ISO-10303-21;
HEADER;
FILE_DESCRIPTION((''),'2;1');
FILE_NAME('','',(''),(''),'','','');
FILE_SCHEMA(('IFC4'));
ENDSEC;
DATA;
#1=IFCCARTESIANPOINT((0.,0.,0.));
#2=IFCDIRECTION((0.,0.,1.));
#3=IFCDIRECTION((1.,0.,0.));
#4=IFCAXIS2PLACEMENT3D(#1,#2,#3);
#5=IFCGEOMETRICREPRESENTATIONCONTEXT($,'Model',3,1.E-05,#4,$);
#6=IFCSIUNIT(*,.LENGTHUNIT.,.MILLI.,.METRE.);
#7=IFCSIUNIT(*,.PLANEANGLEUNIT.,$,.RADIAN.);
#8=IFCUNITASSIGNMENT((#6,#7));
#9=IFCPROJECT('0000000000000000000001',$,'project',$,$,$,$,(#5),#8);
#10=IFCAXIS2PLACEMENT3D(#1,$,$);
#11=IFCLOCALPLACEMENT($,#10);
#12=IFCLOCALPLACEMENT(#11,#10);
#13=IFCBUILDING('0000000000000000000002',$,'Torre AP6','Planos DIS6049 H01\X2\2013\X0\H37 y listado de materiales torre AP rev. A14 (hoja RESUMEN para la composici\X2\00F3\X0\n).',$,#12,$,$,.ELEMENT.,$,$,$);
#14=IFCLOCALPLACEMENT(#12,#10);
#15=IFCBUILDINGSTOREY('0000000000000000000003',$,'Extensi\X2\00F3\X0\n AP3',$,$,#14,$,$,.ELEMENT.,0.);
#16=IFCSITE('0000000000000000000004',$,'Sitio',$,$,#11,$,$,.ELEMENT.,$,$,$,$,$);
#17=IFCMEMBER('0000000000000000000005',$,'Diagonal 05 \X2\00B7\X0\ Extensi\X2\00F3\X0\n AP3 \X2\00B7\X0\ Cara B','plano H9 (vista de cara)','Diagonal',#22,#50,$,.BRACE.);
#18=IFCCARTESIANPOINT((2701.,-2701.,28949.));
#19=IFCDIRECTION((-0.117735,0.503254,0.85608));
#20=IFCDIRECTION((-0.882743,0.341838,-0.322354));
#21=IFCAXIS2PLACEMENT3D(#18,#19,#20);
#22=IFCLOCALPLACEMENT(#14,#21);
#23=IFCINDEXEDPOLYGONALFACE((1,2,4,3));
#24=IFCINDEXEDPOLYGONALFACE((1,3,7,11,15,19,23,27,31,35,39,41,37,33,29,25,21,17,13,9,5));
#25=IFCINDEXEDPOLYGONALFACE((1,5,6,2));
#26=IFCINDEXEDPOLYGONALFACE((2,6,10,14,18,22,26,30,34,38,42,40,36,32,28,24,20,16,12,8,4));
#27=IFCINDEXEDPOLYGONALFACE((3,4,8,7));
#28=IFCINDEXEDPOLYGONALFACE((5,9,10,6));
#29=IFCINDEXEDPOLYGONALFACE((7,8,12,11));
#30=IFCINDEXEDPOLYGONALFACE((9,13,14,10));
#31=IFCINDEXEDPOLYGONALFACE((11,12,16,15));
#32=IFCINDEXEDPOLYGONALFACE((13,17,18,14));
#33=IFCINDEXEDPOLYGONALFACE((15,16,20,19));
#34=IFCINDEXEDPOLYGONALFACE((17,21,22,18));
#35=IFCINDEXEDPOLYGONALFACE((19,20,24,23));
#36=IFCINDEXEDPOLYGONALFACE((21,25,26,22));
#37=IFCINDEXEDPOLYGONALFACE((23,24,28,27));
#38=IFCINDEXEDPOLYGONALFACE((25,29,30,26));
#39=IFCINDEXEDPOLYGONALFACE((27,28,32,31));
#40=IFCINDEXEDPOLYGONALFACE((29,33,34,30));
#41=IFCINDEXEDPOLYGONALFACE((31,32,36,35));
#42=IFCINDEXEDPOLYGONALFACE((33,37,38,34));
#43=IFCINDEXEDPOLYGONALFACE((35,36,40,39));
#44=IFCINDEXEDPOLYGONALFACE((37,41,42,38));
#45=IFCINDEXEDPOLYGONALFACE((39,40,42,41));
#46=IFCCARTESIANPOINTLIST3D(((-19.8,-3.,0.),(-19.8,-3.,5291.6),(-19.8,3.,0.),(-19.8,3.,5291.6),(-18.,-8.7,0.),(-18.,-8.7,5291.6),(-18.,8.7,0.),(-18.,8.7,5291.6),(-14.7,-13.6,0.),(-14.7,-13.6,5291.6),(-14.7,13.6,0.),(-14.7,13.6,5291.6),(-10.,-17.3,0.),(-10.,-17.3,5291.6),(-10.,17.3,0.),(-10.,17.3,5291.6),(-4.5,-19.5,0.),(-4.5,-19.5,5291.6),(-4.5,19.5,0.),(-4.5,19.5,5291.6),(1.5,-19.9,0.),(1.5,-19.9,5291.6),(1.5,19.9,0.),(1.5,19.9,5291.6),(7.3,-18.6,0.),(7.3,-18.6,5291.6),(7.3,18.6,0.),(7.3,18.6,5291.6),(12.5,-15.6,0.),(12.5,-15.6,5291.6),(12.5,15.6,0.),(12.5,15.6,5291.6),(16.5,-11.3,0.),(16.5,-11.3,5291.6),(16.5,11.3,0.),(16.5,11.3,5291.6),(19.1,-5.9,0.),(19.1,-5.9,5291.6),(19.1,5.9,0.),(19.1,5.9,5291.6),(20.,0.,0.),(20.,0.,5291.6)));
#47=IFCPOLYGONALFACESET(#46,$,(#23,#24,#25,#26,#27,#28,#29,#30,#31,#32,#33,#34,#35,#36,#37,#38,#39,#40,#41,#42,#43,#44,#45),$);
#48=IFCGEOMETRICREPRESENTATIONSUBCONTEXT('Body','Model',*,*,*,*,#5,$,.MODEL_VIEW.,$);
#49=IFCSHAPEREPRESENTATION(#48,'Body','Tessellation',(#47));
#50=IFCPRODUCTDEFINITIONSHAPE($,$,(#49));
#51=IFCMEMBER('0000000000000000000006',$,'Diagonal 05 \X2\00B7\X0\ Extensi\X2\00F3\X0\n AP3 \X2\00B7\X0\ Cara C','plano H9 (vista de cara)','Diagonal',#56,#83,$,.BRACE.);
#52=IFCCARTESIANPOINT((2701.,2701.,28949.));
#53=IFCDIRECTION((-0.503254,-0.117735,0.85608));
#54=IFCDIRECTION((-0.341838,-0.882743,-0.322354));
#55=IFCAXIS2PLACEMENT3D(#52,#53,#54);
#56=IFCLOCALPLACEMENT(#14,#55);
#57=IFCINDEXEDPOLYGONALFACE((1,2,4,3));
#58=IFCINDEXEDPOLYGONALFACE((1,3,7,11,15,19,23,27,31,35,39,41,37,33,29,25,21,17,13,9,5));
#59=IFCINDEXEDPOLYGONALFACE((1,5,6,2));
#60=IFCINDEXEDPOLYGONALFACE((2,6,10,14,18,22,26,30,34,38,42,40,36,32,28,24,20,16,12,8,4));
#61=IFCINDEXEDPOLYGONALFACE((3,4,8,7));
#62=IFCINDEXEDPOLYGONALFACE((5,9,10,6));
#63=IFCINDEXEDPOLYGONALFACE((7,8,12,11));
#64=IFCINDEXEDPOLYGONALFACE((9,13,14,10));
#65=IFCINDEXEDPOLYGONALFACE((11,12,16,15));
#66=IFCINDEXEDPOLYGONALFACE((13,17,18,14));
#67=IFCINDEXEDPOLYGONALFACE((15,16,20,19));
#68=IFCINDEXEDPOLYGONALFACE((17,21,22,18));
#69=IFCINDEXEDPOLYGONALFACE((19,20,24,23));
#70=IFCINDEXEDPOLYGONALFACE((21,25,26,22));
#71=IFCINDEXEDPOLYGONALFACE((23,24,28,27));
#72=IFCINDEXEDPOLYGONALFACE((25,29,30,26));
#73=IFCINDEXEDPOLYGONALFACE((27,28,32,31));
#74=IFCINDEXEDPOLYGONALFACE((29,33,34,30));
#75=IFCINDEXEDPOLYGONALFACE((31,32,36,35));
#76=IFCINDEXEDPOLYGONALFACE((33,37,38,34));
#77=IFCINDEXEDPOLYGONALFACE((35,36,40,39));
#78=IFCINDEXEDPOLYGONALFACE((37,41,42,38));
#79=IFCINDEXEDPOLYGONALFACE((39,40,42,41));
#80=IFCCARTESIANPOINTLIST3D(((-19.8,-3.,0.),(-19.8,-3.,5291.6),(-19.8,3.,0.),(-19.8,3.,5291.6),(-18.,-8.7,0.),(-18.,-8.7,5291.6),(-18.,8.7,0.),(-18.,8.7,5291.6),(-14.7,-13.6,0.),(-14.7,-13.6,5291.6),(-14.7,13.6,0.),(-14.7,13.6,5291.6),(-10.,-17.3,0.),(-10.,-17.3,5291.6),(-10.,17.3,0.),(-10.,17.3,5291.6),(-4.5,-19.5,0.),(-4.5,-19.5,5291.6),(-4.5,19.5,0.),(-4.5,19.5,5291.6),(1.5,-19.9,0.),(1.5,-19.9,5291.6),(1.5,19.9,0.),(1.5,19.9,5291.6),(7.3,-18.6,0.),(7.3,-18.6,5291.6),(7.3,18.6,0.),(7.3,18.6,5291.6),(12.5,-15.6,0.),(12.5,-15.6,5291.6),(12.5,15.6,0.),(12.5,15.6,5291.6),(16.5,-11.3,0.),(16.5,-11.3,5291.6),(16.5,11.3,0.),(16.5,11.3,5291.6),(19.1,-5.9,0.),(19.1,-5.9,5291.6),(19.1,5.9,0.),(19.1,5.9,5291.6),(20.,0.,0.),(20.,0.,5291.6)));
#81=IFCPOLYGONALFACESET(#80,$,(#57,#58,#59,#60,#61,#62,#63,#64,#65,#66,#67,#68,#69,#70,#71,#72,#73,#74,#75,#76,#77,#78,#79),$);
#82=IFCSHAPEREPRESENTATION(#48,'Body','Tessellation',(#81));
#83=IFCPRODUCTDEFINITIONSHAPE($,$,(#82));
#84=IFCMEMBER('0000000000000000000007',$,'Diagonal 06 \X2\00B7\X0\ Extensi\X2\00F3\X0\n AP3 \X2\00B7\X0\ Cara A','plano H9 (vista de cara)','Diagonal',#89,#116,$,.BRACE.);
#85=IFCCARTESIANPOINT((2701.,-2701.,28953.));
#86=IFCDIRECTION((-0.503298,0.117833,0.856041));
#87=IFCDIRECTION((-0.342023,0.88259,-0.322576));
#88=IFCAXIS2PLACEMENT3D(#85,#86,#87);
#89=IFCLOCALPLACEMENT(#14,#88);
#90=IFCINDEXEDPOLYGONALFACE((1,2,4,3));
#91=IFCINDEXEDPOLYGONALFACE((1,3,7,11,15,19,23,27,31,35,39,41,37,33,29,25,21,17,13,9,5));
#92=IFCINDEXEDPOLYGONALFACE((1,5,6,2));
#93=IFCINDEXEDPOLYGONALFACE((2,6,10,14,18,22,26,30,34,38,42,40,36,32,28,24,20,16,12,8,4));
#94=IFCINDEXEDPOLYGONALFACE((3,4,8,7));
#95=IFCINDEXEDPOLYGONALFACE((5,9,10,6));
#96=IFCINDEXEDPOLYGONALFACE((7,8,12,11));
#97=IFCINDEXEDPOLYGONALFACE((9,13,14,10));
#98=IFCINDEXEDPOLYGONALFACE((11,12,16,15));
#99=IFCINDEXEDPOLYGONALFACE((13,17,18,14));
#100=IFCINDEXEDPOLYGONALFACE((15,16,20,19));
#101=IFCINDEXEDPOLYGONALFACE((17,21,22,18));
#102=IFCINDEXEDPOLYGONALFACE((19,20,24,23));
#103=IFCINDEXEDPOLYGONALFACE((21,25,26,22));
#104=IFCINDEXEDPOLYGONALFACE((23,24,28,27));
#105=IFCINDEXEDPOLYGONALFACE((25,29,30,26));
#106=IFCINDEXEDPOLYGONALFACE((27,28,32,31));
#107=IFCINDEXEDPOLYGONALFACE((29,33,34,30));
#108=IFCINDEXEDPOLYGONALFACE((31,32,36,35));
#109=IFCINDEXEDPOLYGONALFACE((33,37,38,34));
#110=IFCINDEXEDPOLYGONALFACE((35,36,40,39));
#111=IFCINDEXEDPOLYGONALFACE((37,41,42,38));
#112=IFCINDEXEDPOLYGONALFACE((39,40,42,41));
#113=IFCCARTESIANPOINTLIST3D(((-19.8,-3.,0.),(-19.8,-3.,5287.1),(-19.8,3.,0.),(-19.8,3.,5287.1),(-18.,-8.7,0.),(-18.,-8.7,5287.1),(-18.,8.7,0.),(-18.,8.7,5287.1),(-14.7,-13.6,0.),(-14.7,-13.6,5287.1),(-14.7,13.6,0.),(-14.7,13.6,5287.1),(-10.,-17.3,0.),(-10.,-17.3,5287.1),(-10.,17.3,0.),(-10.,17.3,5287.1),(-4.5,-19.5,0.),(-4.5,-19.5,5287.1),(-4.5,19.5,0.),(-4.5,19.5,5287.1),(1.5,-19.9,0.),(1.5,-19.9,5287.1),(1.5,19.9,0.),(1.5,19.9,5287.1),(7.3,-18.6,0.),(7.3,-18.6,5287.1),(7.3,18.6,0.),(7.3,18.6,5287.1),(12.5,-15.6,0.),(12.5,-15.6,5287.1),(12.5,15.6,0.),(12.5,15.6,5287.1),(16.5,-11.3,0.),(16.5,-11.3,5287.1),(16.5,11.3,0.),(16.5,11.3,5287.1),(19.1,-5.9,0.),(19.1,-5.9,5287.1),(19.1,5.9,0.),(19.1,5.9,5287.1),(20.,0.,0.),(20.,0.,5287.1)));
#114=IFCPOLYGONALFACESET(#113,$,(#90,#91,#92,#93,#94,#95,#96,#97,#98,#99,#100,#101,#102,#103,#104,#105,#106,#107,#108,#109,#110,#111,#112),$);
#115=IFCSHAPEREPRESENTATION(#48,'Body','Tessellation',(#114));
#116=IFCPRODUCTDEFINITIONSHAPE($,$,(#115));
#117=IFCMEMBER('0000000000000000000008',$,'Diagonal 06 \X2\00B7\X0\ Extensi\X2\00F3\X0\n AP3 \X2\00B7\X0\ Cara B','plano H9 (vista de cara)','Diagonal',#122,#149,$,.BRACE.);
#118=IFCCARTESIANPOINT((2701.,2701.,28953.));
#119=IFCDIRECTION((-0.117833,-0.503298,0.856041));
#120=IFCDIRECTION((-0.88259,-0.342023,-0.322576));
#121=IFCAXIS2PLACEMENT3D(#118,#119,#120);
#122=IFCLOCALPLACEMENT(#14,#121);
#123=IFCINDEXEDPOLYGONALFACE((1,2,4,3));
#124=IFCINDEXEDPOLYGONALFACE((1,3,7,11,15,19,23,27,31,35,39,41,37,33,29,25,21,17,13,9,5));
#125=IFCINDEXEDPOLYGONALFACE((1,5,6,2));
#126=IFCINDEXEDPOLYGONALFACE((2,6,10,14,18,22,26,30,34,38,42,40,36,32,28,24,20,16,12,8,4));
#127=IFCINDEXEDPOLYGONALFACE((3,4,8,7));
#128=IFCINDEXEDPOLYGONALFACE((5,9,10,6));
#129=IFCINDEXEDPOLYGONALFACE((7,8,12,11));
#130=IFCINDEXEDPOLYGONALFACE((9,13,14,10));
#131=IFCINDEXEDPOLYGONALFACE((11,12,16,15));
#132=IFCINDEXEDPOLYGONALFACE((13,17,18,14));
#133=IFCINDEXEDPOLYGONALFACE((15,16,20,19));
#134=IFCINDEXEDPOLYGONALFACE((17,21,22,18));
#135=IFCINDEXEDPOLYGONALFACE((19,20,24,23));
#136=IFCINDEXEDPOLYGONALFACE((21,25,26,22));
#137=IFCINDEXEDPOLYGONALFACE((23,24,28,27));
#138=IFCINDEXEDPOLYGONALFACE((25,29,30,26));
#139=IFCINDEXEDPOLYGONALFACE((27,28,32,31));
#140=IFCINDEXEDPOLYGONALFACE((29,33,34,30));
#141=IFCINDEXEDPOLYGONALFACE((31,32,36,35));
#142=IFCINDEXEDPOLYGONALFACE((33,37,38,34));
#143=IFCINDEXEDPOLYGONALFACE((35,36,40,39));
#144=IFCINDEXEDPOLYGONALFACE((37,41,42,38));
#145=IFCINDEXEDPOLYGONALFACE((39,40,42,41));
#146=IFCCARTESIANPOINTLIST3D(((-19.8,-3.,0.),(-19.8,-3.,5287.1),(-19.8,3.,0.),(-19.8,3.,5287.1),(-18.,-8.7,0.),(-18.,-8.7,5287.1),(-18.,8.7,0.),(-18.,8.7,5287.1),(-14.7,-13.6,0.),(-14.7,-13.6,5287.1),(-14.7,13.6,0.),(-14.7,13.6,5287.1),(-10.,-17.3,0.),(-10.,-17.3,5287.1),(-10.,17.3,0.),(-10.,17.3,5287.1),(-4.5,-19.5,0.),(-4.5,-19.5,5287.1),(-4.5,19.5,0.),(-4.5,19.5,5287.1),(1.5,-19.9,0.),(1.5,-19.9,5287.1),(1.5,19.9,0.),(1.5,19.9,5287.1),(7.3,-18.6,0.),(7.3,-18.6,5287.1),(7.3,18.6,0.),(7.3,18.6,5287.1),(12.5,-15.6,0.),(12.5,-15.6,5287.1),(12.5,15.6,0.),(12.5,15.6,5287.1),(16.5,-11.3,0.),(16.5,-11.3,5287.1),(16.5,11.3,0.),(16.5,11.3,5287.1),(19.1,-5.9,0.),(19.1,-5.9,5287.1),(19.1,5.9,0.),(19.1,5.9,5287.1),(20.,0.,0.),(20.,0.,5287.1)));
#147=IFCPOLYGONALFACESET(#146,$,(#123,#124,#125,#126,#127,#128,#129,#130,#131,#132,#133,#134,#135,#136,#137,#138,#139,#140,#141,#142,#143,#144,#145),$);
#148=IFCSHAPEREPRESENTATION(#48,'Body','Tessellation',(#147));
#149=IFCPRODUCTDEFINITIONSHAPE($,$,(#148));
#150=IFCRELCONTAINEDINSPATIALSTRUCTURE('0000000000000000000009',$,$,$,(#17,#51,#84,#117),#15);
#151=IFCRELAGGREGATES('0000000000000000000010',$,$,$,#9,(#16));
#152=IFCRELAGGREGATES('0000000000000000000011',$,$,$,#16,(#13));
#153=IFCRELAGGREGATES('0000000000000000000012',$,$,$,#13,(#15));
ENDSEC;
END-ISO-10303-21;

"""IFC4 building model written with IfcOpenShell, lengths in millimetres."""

from ifc_helpers import new_model, si_unit, frame, origin, origin_with_axes, place, context, subcontext, project, spatial, circle, extrude, element, save


model = new_model("IFC4")

# Units and contexts
model_context = context("Model", 3, precision=1e-05, world=origin_with_axes())
body_context = subcontext(model_context, "Body", "Model", "MODEL_VIEW")
ifc_project = project(units=[si_unit("LENGTHUNIT", "METRE", prefix="MILLI"), si_unit("PLANEANGLEUNIT", "RADIAN")], contexts=[model_context])

# Site, building, storey
site_placement = place(None, origin())
site = spatial("IfcSite", under=ifc_project, at=site_placement, Name="Sitio", CompositionType="ELEMENT")
building_placement = place(site_placement, origin())
building = spatial("IfcBuilding", under=site, at=building_placement, Name="Torre AP6", Description="Planos DIS6049 H01–H37 y listado de materiales torre AP rev. A14 (hoja RESUMEN para la composición).", CompositionType="ELEMENT")
storey_placement = place(building_placement, origin())
storey = spatial("IfcBuildingStorey", under=building, at=storey_placement, Name="Extensión AP3", CompositionType="ELEMENT", Elevation=0.0)

# Members
for number, where, z_axis, x_axis, name in (
    (1, (2701.0, -2701.0, 28949.0), (-0.117735, 0.503254, 0.85608), (-0.882743, 0.341838, -0.322354), "Diagonal 05 · Extensión AP3 · Cara B"),
    (2, (2701.0, 2701.0, 28949.0), (-0.503254, -0.117735, 0.85608), (-0.341838, -0.882743, -0.322354), "Diagonal 05 · Extensión AP3 · Cara C"),
):
    element("IfcMember", number, at=place(storey_placement, frame(where, z_axis=z_axis, x_axis=x_axis)), inside=storey, Name=name, Description="plano H9 (vista de cara)", ObjectType="Diagonal", PredefinedType="BRACE", context=body_context, shape_type="SweptSolid", body=[
        extrude(circle(Radius=20.0), None, (0.0, 0.0, 1.0), 5291.6),
    ])
for number, where, z_axis, x_axis, name in (
    (3, (2701.0, -2701.0, 28953.0), (-0.503298, 0.117833, 0.856041), (-0.342023, 0.88259, -0.322576), "Diagonal 06 · Extensión AP3 · Cara A"),
    (4, (2701.0, 2701.0, 28953.0), (-0.117833, -0.503298, 0.856041), (-0.88259, -0.342023, -0.322576), "Diagonal 06 · Extensión AP3 · Cara B"),
):
    element("IfcMember", number, at=place(storey_placement, frame(where, z_axis=z_axis, x_axis=x_axis)), inside=storey, Name=name, Description="plano H9 (vista de cara)", ObjectType="Diagonal", PredefinedType="BRACE", context=body_context, shape_type="SweptSolid", body=[
        extrude(circle(Radius=20.0), None, (0.0, 0.0, 1.0), 5287.1),
    ])

save(model, "model.ifc")
